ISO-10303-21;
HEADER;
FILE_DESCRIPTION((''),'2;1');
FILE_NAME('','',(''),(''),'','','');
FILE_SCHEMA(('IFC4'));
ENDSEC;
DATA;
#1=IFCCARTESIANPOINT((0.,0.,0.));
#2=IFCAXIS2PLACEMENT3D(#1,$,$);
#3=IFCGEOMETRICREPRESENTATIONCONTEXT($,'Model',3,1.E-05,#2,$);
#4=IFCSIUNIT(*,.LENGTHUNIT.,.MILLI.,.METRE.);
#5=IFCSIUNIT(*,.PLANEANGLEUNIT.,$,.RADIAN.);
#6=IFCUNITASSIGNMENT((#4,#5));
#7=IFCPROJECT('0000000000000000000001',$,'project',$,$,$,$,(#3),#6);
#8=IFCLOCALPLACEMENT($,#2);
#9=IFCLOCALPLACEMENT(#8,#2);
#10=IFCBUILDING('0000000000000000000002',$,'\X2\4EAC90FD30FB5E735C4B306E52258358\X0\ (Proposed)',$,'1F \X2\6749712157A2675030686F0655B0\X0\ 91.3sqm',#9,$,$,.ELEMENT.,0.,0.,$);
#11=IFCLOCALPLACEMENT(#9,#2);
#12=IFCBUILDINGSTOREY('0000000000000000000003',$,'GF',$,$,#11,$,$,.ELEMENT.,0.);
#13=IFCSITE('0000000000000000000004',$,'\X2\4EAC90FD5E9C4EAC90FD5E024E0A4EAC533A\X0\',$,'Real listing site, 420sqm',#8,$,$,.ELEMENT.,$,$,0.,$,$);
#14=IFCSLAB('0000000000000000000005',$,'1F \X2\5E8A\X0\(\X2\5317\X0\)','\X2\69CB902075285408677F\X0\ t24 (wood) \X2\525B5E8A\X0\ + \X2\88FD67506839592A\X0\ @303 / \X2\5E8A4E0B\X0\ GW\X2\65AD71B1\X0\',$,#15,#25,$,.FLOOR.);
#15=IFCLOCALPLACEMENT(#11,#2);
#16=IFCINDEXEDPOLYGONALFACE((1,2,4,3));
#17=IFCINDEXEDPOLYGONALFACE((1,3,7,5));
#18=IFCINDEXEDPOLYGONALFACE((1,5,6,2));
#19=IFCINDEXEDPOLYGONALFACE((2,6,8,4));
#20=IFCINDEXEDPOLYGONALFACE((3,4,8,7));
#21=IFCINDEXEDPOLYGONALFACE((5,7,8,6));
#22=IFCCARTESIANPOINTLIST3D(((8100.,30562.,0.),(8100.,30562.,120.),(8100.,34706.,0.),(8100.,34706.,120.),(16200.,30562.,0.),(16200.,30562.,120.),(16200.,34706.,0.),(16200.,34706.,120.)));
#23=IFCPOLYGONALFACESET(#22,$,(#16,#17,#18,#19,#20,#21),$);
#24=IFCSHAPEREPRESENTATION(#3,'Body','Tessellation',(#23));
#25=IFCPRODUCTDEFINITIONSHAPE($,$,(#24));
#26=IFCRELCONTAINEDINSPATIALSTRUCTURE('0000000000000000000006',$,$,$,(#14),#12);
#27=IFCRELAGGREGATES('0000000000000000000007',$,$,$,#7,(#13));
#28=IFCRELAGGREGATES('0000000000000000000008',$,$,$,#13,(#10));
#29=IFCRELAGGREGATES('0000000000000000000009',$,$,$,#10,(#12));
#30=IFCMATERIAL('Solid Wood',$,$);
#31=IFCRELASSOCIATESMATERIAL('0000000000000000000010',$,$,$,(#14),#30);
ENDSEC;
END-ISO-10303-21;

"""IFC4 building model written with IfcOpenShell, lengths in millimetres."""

from ifc_helpers import new_model, si_unit, frame, frame_2d, origin, place, context, project, spatial, rectangle, extrude, material, element, save


model = new_model("IFC4")

# Units and contexts
model_context = context("Model", 3, precision=1e-05, world=origin())
ifc_project = project(units=[si_unit("LENGTHUNIT", "METRE", prefix="MILLI"), si_unit("PLANEANGLEUNIT", "RADIAN")], contexts=[model_context])

# Site, building, storey
site_placement = place(None, origin())
site = spatial("IfcSite", under=ifc_project, at=site_placement, Name="京都府京都市上京区", ObjectType="Real listing site, 420sqm", CompositionType="ELEMENT", RefElevation=0.0)
building_placement = place(site_placement, origin())
building = spatial("IfcBuilding", under=site, at=building_placement, Name="京都・平屋の別荘 (Proposed)", ObjectType="1F 杉無垢材と漆喰 91.3sqm", CompositionType="ELEMENT", ElevationOfRefHeight=0.0, ElevationOfTerrain=0.0)
storey_placement = place(building_placement, origin())
storey = spatial("IfcBuildingStorey", under=building, at=storey_placement, Name="GF", CompositionType="ELEMENT", Elevation=0.0)

# Shared definitions
ifc_material_1 = material(Name="Solid Wood")

# Slab
slab_placement = place(storey_placement, frame((4050.0, 15281.0, 0.0)))
element("IfcSlab", 1, at=slab_placement, inside=storey, material=ifc_material_1, Name="1F 床(北)", Description="構造用合板 t24 (wood) 剛床 + 製材根太 @303 / 床下 GW断熱", PredefinedType="FLOOR", context=model_context, shape_type="SweptSolid", body=[
    extrude(rectangle(XDim=8100.0, YDim=4144.0, at=frame_2d((4050.0, 2072.0))), frame((4050.0, 15281.0, 0.0)), (0.0, 0.0, 1.0), 120.0),
])

save(model, "model.ifc")
